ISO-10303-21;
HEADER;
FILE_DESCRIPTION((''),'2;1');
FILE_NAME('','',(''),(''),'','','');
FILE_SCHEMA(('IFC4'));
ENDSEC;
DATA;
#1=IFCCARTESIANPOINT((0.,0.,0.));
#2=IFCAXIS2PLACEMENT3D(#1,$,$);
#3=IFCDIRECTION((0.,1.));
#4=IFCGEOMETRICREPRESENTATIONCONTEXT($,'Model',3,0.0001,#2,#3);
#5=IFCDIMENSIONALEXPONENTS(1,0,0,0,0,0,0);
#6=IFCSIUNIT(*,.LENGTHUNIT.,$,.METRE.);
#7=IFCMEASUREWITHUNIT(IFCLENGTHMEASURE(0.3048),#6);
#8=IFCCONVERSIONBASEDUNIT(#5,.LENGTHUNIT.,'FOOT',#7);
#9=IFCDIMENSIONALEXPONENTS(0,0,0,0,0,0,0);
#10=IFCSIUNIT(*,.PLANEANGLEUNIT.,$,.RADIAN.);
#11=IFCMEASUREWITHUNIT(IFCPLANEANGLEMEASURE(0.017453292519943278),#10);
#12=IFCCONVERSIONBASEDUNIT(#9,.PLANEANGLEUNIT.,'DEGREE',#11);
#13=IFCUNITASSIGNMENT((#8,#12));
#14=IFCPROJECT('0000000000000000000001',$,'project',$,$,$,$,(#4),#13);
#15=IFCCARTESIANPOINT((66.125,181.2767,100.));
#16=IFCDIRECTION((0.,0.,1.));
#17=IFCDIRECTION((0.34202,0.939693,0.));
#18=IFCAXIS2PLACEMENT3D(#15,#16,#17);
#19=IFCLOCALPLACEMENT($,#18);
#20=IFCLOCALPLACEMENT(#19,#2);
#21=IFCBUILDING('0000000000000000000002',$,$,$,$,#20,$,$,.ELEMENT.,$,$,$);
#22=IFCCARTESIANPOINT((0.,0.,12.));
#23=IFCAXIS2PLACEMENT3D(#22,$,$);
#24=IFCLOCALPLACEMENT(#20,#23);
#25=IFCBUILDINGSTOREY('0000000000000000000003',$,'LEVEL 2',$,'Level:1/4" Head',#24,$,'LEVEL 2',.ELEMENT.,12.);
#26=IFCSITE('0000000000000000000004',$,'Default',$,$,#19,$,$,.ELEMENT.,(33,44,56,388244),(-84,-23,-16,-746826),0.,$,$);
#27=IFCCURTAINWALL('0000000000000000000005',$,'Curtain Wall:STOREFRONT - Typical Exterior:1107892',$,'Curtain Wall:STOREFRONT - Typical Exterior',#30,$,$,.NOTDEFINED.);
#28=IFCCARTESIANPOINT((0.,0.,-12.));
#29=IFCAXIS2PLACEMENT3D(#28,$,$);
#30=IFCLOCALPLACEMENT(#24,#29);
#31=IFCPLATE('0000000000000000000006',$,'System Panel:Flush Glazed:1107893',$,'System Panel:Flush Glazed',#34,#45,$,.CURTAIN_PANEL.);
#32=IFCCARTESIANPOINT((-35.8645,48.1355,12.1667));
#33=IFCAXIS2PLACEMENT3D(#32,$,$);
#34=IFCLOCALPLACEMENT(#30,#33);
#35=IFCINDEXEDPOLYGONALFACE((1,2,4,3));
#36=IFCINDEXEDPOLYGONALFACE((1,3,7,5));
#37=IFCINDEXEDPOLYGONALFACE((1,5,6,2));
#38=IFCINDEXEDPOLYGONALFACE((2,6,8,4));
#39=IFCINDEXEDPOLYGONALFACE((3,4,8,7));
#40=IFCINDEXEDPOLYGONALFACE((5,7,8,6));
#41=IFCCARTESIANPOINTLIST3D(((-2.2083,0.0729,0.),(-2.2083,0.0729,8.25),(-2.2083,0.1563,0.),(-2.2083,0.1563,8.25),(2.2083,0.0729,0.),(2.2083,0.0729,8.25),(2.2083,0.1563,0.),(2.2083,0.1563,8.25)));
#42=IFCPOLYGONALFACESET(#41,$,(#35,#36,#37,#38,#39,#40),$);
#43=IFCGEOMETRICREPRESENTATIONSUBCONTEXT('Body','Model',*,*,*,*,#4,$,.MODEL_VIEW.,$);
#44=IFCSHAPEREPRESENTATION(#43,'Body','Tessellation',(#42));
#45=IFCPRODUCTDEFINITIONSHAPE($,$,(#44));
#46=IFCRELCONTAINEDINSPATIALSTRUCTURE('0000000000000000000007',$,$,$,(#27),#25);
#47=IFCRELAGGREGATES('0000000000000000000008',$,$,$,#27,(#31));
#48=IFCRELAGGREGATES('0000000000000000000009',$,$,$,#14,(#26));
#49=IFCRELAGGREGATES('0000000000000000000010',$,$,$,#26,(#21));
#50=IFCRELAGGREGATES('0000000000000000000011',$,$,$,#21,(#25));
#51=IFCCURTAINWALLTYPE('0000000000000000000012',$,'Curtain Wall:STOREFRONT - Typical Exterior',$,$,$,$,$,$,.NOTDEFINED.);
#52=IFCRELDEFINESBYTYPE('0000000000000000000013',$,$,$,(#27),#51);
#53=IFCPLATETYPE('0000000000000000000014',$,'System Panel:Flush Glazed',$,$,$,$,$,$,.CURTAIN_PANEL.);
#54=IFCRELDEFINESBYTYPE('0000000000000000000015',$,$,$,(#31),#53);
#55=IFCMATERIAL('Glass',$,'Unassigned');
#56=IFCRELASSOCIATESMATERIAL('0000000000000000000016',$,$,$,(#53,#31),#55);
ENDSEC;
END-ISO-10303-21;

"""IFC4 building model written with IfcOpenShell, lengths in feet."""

from ifc_helpers import new_model, entity, si_unit, converted_unit, direction, frame, frame_2d, origin, place, context, subcontext, project, spatial, rectangle, extrude, source, transform, mapped, material, type_object, type_shapes, element, aggregate, save


model = new_model("IFC4")

# Units and contexts
model_context = context("Model", 3, precision=0.0001, world=origin(), true_north=direction((0.0, 1.0)))
body_context = subcontext(model_context, "Body", "Model", "MODEL_VIEW")
ifc_project = project(units=[converted_unit("LENGTHUNIT", "FOOT", entity("IfcLengthMeasure", 0.3048), si_unit("LENGTHUNIT", "METRE"), dimensions=[1, 0, 0, 0, 0, 0, 0]), converted_unit("PLANEANGLEUNIT", "DEGREE", entity("IfcPlaneAngleMeasure", 0.017453292519943278), si_unit("PLANEANGLEUNIT", "RADIAN"), dimensions=[0, 0, 0, 0, 0, 0, 0])], contexts=[model_context])

# Site, building, storey
site_placement = place(None, frame((66.125, 181.2767, 100.0), z_axis=(0.0, 0.0, 1.0), x_axis=(0.34202, 0.939693, 0.0)))
site = spatial("IfcSite", under=ifc_project, at=site_placement, Name="Default", CompositionType="ELEMENT", RefLatitude=(33, 44, 56, 388244), RefLongitude=(-84, -23, -16, -746826), RefElevation=0.0)
building_placement = place(site_placement, origin())
building = spatial("IfcBuilding", under=site, at=building_placement, CompositionType="ELEMENT")
storey_placement = place(building_placement, frame((0.0, 0.0, 12.0)))
storey = spatial("IfcBuildingStorey", under=building, at=storey_placement, Name="LEVEL 2", ObjectType="Level:1/4\" Head", LongName="LEVEL 2", CompositionType="ELEMENT", Elevation=12.0)

# Curtain wall, plate
curtain_wall_type = type_object("IfcCurtainWallType", Name="Curtain Wall:STOREFRONT - Typical Exterior", PredefinedType="NOTDEFINED")
curtain_wall_placement = place(storey_placement, frame((0.0, 0.0, -12.0)))
curtain_wall = element("IfcCurtainWall", 1, at=curtain_wall_placement, inside=storey, type_object=curtain_wall_type, Name="Curtain Wall:STOREFRONT - Typical Exterior:1107892", ObjectType="Curtain Wall:STOREFRONT - Typical Exterior", PredefinedType="NOTDEFINED")
ifc_material_1 = material(Name="Glass", Category="Unassigned")
plate_type = type_object("IfcPlateType", Name="System Panel:Flush Glazed", PredefinedType="CURTAIN_PANEL", material=ifc_material_1)
shared_shape_1 = source(origin(), body_context, "Body", "SweptSolid", [
    extrude(rectangle(XDim=0.0833, YDim=4.4167, at=frame_2d((0.0, 0.0), x_axis=(1.0, 0.0))), frame((0.0, 0.1146, 0.0), z_axis=(0.0, 0.0, 1.0), x_axis=(0.0, 1.0, 0.0)), (0.0, 0.0, 1.0), 8.25),
])
type_shapes(plate_type, [shared_shape_1])
plate_placement = place(curtain_wall_placement, frame((-35.8645, 48.1355, 12.1667)))
plate = element("IfcPlate", 2, at=plate_placement, type_object=plate_type, material=ifc_material_1, Name="System Panel:Flush Glazed:1107893", ObjectType="System Panel:Flush Glazed", PredefinedType="CURTAIN_PANEL", context=body_context, shape_type="MappedRepresentation", body=[
    mapped(shared_shape_1, transform((0.0, 0.0, 0.0), scale=1.0)),
])
aggregate(curtain_wall, [plate])

save(model, "model.ifc")
